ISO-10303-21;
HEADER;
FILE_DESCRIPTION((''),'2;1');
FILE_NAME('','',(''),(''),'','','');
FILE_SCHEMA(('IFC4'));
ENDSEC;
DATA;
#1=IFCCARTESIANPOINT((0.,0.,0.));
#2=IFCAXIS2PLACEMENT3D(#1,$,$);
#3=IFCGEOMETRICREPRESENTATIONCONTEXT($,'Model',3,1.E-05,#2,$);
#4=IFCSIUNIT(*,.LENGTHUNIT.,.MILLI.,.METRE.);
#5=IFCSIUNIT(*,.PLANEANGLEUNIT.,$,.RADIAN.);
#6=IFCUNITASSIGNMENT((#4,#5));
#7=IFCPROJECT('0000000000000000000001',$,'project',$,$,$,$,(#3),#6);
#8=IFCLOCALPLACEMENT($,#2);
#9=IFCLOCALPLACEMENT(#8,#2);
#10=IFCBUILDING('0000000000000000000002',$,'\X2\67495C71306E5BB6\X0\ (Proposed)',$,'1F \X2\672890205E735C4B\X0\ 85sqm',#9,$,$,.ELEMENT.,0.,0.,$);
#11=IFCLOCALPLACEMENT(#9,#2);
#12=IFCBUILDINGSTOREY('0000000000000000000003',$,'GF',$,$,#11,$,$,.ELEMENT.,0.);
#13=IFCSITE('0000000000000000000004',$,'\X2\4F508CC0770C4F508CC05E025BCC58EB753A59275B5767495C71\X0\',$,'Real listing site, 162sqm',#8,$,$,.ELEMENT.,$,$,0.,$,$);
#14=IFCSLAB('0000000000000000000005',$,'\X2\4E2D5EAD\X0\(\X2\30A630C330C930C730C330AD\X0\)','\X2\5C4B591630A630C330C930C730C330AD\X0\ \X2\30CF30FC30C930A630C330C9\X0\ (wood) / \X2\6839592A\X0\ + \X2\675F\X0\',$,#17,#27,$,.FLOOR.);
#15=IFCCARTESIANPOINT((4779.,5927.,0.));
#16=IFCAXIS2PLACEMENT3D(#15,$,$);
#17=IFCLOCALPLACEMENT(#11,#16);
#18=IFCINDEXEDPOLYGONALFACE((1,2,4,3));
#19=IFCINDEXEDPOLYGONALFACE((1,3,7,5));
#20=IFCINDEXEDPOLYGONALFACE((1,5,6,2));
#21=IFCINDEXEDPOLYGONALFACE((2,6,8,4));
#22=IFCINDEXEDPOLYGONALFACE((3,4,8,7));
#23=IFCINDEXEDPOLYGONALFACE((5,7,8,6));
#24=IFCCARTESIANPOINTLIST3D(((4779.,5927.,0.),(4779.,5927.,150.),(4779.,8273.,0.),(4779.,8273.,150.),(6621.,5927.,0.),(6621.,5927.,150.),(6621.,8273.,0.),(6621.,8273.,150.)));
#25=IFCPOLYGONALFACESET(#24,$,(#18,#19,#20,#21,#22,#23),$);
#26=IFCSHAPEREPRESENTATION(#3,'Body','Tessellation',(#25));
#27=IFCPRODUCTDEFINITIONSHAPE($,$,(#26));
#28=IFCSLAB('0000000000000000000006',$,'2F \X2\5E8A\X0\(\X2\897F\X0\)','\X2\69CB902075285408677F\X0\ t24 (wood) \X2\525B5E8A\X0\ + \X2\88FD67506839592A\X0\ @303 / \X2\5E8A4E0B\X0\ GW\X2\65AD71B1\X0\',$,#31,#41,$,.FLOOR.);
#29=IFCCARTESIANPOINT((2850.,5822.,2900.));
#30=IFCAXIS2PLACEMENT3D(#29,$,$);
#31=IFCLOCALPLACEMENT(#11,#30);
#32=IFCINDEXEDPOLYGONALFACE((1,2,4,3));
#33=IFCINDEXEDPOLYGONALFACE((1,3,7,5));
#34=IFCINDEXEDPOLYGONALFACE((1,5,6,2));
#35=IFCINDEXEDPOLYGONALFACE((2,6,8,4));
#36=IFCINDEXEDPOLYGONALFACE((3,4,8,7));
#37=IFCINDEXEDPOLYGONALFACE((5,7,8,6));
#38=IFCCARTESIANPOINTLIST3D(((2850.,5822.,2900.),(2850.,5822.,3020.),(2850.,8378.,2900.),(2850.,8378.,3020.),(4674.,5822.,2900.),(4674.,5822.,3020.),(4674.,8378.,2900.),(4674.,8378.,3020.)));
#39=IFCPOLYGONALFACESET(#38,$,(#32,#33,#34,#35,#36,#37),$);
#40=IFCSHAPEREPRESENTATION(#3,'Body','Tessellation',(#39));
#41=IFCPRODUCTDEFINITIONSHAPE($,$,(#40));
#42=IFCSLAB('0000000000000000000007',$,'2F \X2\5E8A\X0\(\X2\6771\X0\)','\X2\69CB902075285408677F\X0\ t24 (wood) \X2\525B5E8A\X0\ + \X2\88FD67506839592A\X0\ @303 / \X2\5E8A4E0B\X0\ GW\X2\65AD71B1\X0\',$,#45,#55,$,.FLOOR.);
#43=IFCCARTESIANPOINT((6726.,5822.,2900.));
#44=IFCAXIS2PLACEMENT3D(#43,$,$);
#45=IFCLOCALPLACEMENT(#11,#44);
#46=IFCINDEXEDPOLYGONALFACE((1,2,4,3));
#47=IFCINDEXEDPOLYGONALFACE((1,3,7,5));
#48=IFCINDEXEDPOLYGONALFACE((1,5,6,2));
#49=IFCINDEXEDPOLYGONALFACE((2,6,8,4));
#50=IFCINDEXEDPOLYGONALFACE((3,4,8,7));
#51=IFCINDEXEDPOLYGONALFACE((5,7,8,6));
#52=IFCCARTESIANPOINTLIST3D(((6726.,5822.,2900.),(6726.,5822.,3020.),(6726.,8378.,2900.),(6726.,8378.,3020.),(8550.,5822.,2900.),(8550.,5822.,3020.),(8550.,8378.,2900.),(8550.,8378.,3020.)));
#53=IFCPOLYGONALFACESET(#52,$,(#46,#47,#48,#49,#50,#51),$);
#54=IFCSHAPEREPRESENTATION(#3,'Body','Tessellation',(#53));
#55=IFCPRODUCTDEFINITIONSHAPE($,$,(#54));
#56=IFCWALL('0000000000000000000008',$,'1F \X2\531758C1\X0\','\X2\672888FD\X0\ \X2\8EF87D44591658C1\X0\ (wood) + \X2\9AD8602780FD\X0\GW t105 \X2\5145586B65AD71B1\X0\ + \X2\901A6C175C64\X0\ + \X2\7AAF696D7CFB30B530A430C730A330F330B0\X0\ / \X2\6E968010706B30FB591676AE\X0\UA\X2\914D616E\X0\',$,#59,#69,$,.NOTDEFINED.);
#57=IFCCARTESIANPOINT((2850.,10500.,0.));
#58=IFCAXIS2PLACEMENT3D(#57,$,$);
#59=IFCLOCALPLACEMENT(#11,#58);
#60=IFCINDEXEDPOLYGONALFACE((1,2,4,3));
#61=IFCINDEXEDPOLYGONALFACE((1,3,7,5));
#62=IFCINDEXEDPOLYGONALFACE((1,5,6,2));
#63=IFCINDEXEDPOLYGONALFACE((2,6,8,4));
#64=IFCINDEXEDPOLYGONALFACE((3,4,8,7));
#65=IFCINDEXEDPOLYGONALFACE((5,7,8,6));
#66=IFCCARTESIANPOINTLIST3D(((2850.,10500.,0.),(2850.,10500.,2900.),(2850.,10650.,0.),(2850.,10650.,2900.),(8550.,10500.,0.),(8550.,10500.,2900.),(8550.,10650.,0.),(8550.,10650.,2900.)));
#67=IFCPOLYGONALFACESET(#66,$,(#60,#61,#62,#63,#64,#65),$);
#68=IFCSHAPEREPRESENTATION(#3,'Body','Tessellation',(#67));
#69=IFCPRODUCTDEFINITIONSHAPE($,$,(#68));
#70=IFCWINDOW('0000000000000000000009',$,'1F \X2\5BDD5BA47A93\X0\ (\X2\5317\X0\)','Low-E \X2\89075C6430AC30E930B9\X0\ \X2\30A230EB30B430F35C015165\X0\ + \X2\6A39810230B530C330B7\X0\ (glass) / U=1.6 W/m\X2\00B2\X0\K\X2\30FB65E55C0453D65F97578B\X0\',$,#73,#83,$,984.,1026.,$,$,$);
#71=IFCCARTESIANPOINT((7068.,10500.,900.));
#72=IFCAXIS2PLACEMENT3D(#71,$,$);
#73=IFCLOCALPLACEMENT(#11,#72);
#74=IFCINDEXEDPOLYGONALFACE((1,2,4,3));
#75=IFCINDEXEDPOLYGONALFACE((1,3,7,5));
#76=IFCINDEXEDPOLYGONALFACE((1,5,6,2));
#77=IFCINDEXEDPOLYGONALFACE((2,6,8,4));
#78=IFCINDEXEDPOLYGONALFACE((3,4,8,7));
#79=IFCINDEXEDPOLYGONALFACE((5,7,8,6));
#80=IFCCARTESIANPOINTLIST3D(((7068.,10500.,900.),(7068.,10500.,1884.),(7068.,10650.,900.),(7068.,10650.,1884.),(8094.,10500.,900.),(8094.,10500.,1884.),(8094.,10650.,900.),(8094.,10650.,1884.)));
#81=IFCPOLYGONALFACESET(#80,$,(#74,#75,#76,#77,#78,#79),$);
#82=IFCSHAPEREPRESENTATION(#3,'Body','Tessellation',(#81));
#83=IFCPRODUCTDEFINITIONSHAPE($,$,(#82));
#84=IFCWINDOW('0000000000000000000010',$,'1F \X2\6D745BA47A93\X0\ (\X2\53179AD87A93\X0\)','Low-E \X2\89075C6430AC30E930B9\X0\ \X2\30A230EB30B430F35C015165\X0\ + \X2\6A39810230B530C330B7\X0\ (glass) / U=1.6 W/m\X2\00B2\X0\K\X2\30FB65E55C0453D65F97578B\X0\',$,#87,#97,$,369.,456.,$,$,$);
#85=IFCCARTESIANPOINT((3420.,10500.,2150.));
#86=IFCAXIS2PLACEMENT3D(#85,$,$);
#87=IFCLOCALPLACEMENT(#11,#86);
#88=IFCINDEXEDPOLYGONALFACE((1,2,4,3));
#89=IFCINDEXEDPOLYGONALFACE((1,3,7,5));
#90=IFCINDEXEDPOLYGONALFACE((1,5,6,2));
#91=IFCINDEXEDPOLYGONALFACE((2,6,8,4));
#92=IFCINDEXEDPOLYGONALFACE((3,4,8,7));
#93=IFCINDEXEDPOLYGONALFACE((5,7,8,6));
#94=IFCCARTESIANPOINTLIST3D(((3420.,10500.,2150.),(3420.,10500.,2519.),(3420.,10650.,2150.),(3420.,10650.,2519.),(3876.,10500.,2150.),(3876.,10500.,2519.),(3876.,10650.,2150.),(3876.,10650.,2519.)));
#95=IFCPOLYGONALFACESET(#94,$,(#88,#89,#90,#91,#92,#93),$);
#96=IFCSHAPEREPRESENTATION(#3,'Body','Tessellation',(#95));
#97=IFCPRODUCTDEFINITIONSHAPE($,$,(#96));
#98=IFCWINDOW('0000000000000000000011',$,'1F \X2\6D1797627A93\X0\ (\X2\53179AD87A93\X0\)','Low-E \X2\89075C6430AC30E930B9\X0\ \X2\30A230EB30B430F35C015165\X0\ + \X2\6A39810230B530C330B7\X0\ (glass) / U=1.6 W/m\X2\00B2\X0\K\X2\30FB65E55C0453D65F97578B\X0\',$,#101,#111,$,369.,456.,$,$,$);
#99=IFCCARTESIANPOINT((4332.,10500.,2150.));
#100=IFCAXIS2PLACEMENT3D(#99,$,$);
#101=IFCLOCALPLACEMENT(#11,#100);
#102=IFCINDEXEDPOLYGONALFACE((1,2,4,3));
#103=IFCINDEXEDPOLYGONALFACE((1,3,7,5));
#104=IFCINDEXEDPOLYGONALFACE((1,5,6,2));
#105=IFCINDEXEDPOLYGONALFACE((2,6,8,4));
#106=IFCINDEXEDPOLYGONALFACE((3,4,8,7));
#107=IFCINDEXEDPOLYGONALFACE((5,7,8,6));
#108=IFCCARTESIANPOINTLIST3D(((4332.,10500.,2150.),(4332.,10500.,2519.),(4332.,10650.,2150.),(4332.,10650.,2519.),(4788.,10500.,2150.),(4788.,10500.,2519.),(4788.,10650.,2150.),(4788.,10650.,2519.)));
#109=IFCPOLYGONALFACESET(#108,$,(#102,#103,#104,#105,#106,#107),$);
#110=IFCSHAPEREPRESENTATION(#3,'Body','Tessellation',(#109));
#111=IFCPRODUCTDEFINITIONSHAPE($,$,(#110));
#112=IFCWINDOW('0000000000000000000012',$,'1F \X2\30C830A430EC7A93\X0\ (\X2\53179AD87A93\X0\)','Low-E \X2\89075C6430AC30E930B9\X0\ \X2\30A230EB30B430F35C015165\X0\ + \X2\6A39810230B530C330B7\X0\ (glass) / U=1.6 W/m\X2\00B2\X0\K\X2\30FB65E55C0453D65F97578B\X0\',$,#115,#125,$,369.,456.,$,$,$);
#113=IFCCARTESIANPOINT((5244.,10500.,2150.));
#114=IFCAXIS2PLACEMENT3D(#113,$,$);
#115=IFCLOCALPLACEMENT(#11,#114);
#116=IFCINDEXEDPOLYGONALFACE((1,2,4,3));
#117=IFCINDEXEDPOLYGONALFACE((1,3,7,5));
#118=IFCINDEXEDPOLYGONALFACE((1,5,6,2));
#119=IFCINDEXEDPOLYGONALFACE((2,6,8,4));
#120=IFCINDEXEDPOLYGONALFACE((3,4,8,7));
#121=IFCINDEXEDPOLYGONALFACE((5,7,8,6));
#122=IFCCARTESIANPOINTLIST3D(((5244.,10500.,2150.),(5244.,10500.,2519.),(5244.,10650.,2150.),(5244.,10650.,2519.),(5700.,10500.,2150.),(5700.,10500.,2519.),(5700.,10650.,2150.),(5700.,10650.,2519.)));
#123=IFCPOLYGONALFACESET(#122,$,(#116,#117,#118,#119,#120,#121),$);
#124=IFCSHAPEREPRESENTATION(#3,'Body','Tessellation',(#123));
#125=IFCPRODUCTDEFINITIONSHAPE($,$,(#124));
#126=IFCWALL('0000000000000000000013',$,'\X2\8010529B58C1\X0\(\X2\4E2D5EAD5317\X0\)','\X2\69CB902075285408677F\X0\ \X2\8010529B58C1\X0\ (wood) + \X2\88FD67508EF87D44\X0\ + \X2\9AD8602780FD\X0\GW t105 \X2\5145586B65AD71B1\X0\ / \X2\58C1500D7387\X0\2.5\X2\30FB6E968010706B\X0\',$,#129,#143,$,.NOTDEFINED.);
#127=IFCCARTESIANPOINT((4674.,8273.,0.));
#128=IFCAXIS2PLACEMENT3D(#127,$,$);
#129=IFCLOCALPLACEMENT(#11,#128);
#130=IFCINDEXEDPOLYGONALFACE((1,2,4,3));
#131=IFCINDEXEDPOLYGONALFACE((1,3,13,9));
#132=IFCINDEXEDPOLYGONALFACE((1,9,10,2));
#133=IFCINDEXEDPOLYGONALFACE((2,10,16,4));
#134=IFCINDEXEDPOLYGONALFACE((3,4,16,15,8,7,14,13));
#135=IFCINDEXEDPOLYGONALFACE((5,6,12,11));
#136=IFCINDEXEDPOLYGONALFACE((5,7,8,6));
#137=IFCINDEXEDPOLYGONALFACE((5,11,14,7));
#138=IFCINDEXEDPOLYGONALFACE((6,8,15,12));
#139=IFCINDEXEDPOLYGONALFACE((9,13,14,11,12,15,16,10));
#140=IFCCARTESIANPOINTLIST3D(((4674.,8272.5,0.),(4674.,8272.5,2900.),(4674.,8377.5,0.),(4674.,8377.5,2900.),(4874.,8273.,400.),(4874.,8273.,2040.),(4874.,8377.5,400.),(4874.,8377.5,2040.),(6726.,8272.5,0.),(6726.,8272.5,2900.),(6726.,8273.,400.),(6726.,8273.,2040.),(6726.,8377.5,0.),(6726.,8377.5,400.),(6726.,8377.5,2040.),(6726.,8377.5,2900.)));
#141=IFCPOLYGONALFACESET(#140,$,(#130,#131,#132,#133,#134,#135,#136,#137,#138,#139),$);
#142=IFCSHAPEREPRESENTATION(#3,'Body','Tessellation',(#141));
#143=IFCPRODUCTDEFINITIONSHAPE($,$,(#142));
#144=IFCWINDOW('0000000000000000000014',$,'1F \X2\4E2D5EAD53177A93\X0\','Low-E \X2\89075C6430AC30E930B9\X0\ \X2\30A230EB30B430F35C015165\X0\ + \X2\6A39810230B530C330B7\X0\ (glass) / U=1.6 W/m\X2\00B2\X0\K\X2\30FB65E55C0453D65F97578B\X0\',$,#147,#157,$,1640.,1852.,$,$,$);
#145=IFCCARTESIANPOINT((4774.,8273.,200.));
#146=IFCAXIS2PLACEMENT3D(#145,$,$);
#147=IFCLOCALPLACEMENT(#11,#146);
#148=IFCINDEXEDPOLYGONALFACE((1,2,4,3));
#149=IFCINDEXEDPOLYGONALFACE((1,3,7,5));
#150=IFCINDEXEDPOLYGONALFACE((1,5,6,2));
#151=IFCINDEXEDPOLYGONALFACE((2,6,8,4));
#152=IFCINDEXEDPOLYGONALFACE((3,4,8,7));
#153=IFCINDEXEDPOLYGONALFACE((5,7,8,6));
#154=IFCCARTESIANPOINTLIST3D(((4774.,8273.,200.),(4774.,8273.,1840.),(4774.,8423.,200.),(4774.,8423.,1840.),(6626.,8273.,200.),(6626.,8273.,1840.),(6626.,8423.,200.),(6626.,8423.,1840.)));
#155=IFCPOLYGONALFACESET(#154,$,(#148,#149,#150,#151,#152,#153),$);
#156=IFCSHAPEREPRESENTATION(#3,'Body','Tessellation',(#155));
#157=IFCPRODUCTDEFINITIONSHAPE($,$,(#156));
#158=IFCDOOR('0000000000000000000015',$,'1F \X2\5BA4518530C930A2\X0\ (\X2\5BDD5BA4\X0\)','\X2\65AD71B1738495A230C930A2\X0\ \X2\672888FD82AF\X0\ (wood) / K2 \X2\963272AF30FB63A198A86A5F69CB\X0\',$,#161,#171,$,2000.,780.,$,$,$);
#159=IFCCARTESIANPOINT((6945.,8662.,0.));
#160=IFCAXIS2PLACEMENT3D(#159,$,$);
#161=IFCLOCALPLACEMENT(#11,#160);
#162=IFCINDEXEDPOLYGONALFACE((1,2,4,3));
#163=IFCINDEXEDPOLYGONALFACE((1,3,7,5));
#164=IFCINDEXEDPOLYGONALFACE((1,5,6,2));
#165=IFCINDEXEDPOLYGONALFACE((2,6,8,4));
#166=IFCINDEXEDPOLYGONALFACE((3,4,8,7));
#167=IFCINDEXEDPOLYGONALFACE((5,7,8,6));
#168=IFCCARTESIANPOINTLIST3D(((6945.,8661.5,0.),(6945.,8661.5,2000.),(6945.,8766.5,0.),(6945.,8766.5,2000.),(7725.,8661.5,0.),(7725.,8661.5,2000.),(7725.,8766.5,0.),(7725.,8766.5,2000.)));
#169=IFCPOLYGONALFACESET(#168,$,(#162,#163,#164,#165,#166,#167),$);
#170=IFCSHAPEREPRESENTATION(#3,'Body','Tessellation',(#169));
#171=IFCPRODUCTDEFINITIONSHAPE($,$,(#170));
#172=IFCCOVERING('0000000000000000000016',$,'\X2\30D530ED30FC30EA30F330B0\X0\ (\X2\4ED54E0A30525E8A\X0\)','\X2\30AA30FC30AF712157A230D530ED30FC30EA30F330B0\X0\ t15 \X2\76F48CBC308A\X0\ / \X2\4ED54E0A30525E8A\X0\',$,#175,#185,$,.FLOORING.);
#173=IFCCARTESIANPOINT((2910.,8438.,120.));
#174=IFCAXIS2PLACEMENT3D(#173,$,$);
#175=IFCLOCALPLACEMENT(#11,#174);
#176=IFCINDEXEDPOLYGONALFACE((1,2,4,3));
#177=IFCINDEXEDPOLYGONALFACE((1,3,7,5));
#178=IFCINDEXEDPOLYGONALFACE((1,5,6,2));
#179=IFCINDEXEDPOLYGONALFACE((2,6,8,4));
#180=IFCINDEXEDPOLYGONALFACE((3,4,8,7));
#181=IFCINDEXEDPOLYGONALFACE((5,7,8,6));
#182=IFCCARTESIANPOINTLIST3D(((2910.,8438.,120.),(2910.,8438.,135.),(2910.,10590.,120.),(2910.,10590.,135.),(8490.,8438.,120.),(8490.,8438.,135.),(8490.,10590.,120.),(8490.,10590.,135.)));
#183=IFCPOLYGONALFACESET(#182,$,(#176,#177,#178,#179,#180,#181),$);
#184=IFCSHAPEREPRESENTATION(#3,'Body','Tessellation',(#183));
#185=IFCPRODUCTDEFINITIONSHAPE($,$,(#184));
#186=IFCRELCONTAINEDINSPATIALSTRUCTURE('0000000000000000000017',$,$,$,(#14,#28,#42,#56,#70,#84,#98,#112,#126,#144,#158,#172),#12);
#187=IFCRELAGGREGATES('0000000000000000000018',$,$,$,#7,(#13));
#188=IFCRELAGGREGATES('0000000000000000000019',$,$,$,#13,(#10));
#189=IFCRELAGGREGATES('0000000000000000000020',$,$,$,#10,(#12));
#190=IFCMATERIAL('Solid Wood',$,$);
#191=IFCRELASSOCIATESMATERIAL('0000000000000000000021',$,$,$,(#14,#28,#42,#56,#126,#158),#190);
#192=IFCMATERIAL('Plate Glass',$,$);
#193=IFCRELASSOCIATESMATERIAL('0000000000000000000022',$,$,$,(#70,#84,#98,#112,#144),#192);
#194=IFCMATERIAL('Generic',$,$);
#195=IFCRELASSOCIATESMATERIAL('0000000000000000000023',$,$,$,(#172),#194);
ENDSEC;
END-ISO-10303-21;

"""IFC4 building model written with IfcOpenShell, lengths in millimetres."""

from ifc_helpers import new_model, si_unit, frame, frame_2d, origin, place, context, project, spatial, rectangle, extrude, material, element, fill, save


model = new_model("IFC4")

# Units and contexts
model_context = context("Model", 3, precision=1e-05, world=origin())
ifc_project = project(units=[si_unit("LENGTHUNIT", "METRE", prefix="MILLI"), si_unit("PLANEANGLEUNIT", "RADIAN")], contexts=[model_context])

# Site, building, storey
site_placement = place(None, origin())
site = spatial("IfcSite", under=ifc_project, at=site_placement, Name="佐賀県佐賀市富士町大字杉山", ObjectType="Real listing site, 162sqm", CompositionType="ELEMENT", RefElevation=0.0)
building_placement = place(site_placement, origin())
building = spatial("IfcBuilding", under=site, at=building_placement, Name="杉山の家 (Proposed)", ObjectType="1F 木造平屋 85sqm", CompositionType="ELEMENT", ElevationOfRefHeight=0.0, ElevationOfTerrain=0.0)
storey_placement = place(building_placement, origin())
storey = spatial("IfcBuildingStorey", under=building, at=storey_placement, Name="GF", CompositionType="ELEMENT", Elevation=0.0)

# Slabs
ifc_material_1 = material(Name="Solid Wood")
slab_1_placement = place(storey_placement, frame((4779.0, 5927.0, 0.0)))
element("IfcSlab", 1, at=slab_1_placement, inside=storey, material=ifc_material_1, Name="中庭(ウッドデッキ)", Description="屋外ウッドデッキ ハードウッド (wood) / 根太 + 束", PredefinedType="FLOOR", context=model_context, shape_type="SweptSolid", body=[
    extrude(rectangle(XDim=1842.0, YDim=2346.0, at=frame_2d((921.0, 1173.0))), frame((4779.0, 5927.0, 0.0)), (0.0, 0.0, 1.0), 150.0),
])
slab_2_placement = place(storey_placement, frame((2850.0, 5822.0, 2900.0)))
element("IfcSlab", 2, at=slab_2_placement, inside=storey, material=ifc_material_1, Name="2F 床(西)", Description="構造用合板 t24 (wood) 剛床 + 製材根太 @303 / 床下 GW断熱", PredefinedType="FLOOR", context=model_context, shape_type="SweptSolid", body=[
    extrude(rectangle(XDim=1824.0, YDim=2556.0, at=frame_2d((912.0, 1278.0))), frame((2850.0, 5822.0, 2900.0)), (0.0, 0.0, 1.0), 120.0),
])
slab_3_placement = place(storey_placement, frame((6726.0, 5822.0, 2900.0)))
element("IfcSlab", 3, at=slab_3_placement, inside=storey, material=ifc_material_1, Name="2F 床(東)", Description="構造用合板 t24 (wood) 剛床 + 製材根太 @303 / 床下 GW断熱", PredefinedType="FLOOR", context=model_context, shape_type="SweptSolid", body=[
    extrude(rectangle(XDim=1824.0, YDim=2556.0, at=frame_2d((912.0, 1278.0))), frame((6726.0, 5822.0, 2900.0)), (0.0, 0.0, 1.0), 120.0),
])

# Wall, openings, windows
wall_1_placement = place(storey_placement, frame((2850.0, 10500.0, 0.0)))
wall_1 = element("IfcWall", 4, at=wall_1_placement, inside=storey, material=ifc_material_1, Name="1F 北壁", Description="木製 軸組外壁 (wood) + 高性能GW t105 充填断熱 + 通気層 + 窯業系サイディング / 準耐火・外皮UA配慮", PredefinedType="NOTDEFINED", context=model_context, shape_type="SweptSolid", body=[
    extrude(rectangle(XDim=5700.0, YDim=150.0, at=frame_2d((2850.0, 75.0))), frame((2850.0, 10500.0, 0.0)), (0.0, 0.0, 1.0), 2900.0),
])
opening_1_placement = place(storey_placement, frame((7068.0, 10500.0, 900.0)))
opening_1 = element("IfcOpeningElement", 5, at=opening_1_placement, cuts=wall_1, PredefinedType="NOTDEFINED", context=model_context, shape_type="SweptSolid", body=[
    extrude(rectangle(XDim=1026.0, YDim=150.0, at=frame_2d((513.0, 75.0))), frame((7068.0, 10500.0, 900.0)), (0.0, 0.0, 1.0), 984.0),
])
opening_2_placement = place(storey_placement, frame((3420.0, 10500.0, 2150.0)))
opening_2 = element("IfcOpeningElement", 6, at=opening_2_placement, cuts=wall_1, PredefinedType="NOTDEFINED", context=model_context, shape_type="SweptSolid", body=[
    extrude(rectangle(XDim=456.0, YDim=150.0, at=frame_2d((228.0, 75.0))), frame((3420.0, 10500.0, 2150.0)), (0.0, 0.0, 1.0), 369.0),
])
opening_3_placement = place(storey_placement, frame((4332.0, 10500.0, 2150.0)))
opening_3 = element("IfcOpeningElement", 7, at=opening_3_placement, cuts=wall_1, PredefinedType="NOTDEFINED", context=model_context, shape_type="SweptSolid", body=[
    extrude(rectangle(XDim=456.0, YDim=150.0, at=frame_2d((228.0, 75.0))), frame((4332.0, 10500.0, 2150.0)), (0.0, 0.0, 1.0), 369.0),
])
opening_4_placement = place(storey_placement, frame((5244.0, 10500.0, 2150.0)))
opening_4 = element("IfcOpeningElement", 8, at=opening_4_placement, cuts=wall_1, PredefinedType="NOTDEFINED", context=model_context, shape_type="SweptSolid", body=[
    extrude(rectangle(XDim=456.0, YDim=150.0, at=frame_2d((228.0, 75.0))), frame((5244.0, 10500.0, 2150.0)), (0.0, 0.0, 1.0), 369.0),
])
ifc_material_2 = material(Name="Plate Glass")
window_1_placement = place(storey_placement, frame((7068.0, 10500.0, 900.0)))
window_1 = element("IfcWindow", 9, at=window_1_placement, inside=storey, material=ifc_material_2, Name="1F 寝室窓 (北)", Description="Low-E 複層ガラス アルゴン封入 + 樹脂サッシ (glass) / U=1.6 W/m²K・日射取得型", OverallHeight=984.0, OverallWidth=1026.0, context=model_context, shape_type="SweptSolid", body=[
    extrude(rectangle(XDim=1026.0, YDim=150.0, at=frame_2d((513.0, 75.0))), frame((7068.0, 10500.0, 900.0)), (0.0, 0.0, 1.0), 984.0),
])
fill(opening_1, window_1)
window_2_placement = place(storey_placement, frame((3420.0, 10500.0, 2150.0)))
window_2 = element("IfcWindow", 10, at=window_2_placement, inside=storey, material=ifc_material_2, Name="1F 浴室窓 (北高窓)", Description="Low-E 複層ガラス アルゴン封入 + 樹脂サッシ (glass) / U=1.6 W/m²K・日射取得型", OverallHeight=369.0, OverallWidth=456.0, context=model_context, shape_type="SweptSolid", body=[
    extrude(rectangle(XDim=456.0, YDim=150.0, at=frame_2d((228.0, 75.0))), frame((3420.0, 10500.0, 2150.0)), (0.0, 0.0, 1.0), 369.0),
])
fill(opening_2, window_2)
window_3_placement = place(storey_placement, frame((4332.0, 10500.0, 2150.0)))
window_3 = element("IfcWindow", 11, at=window_3_placement, inside=storey, material=ifc_material_2, Name="1F 洗面窓 (北高窓)", Description="Low-E 複層ガラス アルゴン封入 + 樹脂サッシ (glass) / U=1.6 W/m²K・日射取得型", OverallHeight=369.0, OverallWidth=456.0, context=model_context, shape_type="SweptSolid", body=[
    extrude(rectangle(XDim=456.0, YDim=150.0, at=frame_2d((228.0, 75.0))), frame((4332.0, 10500.0, 2150.0)), (0.0, 0.0, 1.0), 369.0),
])
fill(opening_3, window_3)
window_4_placement = place(storey_placement, frame((5244.0, 10500.0, 2150.0)))
window_4 = element("IfcWindow", 12, at=window_4_placement, inside=storey, material=ifc_material_2, Name="1F トイレ窓 (北高窓)", Description="Low-E 複層ガラス アルゴン封入 + 樹脂サッシ (glass) / U=1.6 W/m²K・日射取得型", OverallHeight=369.0, OverallWidth=456.0, context=model_context, shape_type="SweptSolid", body=[
    extrude(rectangle(XDim=456.0, YDim=150.0, at=frame_2d((228.0, 75.0))), frame((5244.0, 10500.0, 2150.0)), (0.0, 0.0, 1.0), 369.0),
])
fill(opening_4, window_4)

# Wall, opening, window
wall_2_placement = place(storey_placement, frame((4674.0, 8273.0, 0.0)))
wall_2 = element("IfcWall", 13, at=wall_2_placement, inside=storey, material=ifc_material_1, Name="耐力壁(中庭北)", Description="構造用合板 耐力壁 (wood) + 製材軸組 + 高性能GW t105 充填断熱 / 壁倍率2.5・準耐火", PredefinedType="NOTDEFINED", context=model_context, shape_type="SweptSolid", body=[
    extrude(rectangle(XDim=2052.0, YDim=105.0, at=frame_2d((1026.0, 52.0))), frame((4674.0, 8273.0, 0.0)), (0.0, 0.0, 1.0), 2900.0),
])
opening_5_placement = place(storey_placement, frame((4774.0, 8273.0, 200.0)))
opening_5 = element("IfcOpeningElement", 14, at=opening_5_placement, cuts=wall_2, PredefinedType="NOTDEFINED", context=model_context, shape_type="SweptSolid", body=[
    extrude(rectangle(XDim=1852.0, YDim=150.0, at=frame_2d((926.0, 75.0))), frame((4774.0, 8273.0, 200.0)), (0.0, 0.0, 1.0), 1640.0),
])
window_5_placement = place(storey_placement, frame((4774.0, 8273.0, 200.0)))
window_5 = element("IfcWindow", 15, at=window_5_placement, inside=storey, material=ifc_material_2, Name="1F 中庭北窓", Description="Low-E 複層ガラス アルゴン封入 + 樹脂サッシ (glass) / U=1.6 W/m²K・日射取得型", OverallHeight=1640.0, OverallWidth=1852.0, context=model_context, shape_type="SweptSolid", body=[
    extrude(rectangle(XDim=1852.0, YDim=150.0, at=frame_2d((926.0, 75.0))), frame((4774.0, 8273.0, 200.0)), (0.0, 0.0, 1.0), 1640.0),
])
fill(opening_5, window_5)

# Door
door_1_placement = place(storey_placement, frame((6945.0, 8662.0, 0.0)))
element("IfcDoor", 16, at=door_1_placement, inside=storey, material=ifc_material_1, Name="1F 室内ドア (寝室)", Description="断熱玄関ドア 木製芯 (wood) / K2 防犯・採風機構", OverallHeight=2000.0, OverallWidth=780.0, context=model_context, shape_type="SweptSolid", body=[
    extrude(rectangle(XDim=780.0, YDim=105.0, at=frame_2d((390.0, 52.0))), frame((6945.0, 8662.0, 0.0)), (0.0, 0.0, 1.0), 2000.0),
])

# Covering
ifc_material_3 = material(Name="Generic")
covering_1_placement = place(storey_placement, frame((2910.0, 8438.0, 120.0)))
element("IfcCovering", 17, at=covering_1_placement, inside=storey, material=ifc_material_3, Name="フローリング (仕上げ床)", Description="オーク無垢フローリング t15 直貼り / 仕上げ床", PredefinedType="FLOORING", context=model_context, shape_type="SweptSolid", body=[
    extrude(rectangle(XDim=5580.0, YDim=2152.0, at=frame_2d((2790.0, 1076.0))), frame((2910.0, 8438.0, 120.0)), (0.0, 0.0, 1.0), 15.0),
])

save(model, "model.ifc")
